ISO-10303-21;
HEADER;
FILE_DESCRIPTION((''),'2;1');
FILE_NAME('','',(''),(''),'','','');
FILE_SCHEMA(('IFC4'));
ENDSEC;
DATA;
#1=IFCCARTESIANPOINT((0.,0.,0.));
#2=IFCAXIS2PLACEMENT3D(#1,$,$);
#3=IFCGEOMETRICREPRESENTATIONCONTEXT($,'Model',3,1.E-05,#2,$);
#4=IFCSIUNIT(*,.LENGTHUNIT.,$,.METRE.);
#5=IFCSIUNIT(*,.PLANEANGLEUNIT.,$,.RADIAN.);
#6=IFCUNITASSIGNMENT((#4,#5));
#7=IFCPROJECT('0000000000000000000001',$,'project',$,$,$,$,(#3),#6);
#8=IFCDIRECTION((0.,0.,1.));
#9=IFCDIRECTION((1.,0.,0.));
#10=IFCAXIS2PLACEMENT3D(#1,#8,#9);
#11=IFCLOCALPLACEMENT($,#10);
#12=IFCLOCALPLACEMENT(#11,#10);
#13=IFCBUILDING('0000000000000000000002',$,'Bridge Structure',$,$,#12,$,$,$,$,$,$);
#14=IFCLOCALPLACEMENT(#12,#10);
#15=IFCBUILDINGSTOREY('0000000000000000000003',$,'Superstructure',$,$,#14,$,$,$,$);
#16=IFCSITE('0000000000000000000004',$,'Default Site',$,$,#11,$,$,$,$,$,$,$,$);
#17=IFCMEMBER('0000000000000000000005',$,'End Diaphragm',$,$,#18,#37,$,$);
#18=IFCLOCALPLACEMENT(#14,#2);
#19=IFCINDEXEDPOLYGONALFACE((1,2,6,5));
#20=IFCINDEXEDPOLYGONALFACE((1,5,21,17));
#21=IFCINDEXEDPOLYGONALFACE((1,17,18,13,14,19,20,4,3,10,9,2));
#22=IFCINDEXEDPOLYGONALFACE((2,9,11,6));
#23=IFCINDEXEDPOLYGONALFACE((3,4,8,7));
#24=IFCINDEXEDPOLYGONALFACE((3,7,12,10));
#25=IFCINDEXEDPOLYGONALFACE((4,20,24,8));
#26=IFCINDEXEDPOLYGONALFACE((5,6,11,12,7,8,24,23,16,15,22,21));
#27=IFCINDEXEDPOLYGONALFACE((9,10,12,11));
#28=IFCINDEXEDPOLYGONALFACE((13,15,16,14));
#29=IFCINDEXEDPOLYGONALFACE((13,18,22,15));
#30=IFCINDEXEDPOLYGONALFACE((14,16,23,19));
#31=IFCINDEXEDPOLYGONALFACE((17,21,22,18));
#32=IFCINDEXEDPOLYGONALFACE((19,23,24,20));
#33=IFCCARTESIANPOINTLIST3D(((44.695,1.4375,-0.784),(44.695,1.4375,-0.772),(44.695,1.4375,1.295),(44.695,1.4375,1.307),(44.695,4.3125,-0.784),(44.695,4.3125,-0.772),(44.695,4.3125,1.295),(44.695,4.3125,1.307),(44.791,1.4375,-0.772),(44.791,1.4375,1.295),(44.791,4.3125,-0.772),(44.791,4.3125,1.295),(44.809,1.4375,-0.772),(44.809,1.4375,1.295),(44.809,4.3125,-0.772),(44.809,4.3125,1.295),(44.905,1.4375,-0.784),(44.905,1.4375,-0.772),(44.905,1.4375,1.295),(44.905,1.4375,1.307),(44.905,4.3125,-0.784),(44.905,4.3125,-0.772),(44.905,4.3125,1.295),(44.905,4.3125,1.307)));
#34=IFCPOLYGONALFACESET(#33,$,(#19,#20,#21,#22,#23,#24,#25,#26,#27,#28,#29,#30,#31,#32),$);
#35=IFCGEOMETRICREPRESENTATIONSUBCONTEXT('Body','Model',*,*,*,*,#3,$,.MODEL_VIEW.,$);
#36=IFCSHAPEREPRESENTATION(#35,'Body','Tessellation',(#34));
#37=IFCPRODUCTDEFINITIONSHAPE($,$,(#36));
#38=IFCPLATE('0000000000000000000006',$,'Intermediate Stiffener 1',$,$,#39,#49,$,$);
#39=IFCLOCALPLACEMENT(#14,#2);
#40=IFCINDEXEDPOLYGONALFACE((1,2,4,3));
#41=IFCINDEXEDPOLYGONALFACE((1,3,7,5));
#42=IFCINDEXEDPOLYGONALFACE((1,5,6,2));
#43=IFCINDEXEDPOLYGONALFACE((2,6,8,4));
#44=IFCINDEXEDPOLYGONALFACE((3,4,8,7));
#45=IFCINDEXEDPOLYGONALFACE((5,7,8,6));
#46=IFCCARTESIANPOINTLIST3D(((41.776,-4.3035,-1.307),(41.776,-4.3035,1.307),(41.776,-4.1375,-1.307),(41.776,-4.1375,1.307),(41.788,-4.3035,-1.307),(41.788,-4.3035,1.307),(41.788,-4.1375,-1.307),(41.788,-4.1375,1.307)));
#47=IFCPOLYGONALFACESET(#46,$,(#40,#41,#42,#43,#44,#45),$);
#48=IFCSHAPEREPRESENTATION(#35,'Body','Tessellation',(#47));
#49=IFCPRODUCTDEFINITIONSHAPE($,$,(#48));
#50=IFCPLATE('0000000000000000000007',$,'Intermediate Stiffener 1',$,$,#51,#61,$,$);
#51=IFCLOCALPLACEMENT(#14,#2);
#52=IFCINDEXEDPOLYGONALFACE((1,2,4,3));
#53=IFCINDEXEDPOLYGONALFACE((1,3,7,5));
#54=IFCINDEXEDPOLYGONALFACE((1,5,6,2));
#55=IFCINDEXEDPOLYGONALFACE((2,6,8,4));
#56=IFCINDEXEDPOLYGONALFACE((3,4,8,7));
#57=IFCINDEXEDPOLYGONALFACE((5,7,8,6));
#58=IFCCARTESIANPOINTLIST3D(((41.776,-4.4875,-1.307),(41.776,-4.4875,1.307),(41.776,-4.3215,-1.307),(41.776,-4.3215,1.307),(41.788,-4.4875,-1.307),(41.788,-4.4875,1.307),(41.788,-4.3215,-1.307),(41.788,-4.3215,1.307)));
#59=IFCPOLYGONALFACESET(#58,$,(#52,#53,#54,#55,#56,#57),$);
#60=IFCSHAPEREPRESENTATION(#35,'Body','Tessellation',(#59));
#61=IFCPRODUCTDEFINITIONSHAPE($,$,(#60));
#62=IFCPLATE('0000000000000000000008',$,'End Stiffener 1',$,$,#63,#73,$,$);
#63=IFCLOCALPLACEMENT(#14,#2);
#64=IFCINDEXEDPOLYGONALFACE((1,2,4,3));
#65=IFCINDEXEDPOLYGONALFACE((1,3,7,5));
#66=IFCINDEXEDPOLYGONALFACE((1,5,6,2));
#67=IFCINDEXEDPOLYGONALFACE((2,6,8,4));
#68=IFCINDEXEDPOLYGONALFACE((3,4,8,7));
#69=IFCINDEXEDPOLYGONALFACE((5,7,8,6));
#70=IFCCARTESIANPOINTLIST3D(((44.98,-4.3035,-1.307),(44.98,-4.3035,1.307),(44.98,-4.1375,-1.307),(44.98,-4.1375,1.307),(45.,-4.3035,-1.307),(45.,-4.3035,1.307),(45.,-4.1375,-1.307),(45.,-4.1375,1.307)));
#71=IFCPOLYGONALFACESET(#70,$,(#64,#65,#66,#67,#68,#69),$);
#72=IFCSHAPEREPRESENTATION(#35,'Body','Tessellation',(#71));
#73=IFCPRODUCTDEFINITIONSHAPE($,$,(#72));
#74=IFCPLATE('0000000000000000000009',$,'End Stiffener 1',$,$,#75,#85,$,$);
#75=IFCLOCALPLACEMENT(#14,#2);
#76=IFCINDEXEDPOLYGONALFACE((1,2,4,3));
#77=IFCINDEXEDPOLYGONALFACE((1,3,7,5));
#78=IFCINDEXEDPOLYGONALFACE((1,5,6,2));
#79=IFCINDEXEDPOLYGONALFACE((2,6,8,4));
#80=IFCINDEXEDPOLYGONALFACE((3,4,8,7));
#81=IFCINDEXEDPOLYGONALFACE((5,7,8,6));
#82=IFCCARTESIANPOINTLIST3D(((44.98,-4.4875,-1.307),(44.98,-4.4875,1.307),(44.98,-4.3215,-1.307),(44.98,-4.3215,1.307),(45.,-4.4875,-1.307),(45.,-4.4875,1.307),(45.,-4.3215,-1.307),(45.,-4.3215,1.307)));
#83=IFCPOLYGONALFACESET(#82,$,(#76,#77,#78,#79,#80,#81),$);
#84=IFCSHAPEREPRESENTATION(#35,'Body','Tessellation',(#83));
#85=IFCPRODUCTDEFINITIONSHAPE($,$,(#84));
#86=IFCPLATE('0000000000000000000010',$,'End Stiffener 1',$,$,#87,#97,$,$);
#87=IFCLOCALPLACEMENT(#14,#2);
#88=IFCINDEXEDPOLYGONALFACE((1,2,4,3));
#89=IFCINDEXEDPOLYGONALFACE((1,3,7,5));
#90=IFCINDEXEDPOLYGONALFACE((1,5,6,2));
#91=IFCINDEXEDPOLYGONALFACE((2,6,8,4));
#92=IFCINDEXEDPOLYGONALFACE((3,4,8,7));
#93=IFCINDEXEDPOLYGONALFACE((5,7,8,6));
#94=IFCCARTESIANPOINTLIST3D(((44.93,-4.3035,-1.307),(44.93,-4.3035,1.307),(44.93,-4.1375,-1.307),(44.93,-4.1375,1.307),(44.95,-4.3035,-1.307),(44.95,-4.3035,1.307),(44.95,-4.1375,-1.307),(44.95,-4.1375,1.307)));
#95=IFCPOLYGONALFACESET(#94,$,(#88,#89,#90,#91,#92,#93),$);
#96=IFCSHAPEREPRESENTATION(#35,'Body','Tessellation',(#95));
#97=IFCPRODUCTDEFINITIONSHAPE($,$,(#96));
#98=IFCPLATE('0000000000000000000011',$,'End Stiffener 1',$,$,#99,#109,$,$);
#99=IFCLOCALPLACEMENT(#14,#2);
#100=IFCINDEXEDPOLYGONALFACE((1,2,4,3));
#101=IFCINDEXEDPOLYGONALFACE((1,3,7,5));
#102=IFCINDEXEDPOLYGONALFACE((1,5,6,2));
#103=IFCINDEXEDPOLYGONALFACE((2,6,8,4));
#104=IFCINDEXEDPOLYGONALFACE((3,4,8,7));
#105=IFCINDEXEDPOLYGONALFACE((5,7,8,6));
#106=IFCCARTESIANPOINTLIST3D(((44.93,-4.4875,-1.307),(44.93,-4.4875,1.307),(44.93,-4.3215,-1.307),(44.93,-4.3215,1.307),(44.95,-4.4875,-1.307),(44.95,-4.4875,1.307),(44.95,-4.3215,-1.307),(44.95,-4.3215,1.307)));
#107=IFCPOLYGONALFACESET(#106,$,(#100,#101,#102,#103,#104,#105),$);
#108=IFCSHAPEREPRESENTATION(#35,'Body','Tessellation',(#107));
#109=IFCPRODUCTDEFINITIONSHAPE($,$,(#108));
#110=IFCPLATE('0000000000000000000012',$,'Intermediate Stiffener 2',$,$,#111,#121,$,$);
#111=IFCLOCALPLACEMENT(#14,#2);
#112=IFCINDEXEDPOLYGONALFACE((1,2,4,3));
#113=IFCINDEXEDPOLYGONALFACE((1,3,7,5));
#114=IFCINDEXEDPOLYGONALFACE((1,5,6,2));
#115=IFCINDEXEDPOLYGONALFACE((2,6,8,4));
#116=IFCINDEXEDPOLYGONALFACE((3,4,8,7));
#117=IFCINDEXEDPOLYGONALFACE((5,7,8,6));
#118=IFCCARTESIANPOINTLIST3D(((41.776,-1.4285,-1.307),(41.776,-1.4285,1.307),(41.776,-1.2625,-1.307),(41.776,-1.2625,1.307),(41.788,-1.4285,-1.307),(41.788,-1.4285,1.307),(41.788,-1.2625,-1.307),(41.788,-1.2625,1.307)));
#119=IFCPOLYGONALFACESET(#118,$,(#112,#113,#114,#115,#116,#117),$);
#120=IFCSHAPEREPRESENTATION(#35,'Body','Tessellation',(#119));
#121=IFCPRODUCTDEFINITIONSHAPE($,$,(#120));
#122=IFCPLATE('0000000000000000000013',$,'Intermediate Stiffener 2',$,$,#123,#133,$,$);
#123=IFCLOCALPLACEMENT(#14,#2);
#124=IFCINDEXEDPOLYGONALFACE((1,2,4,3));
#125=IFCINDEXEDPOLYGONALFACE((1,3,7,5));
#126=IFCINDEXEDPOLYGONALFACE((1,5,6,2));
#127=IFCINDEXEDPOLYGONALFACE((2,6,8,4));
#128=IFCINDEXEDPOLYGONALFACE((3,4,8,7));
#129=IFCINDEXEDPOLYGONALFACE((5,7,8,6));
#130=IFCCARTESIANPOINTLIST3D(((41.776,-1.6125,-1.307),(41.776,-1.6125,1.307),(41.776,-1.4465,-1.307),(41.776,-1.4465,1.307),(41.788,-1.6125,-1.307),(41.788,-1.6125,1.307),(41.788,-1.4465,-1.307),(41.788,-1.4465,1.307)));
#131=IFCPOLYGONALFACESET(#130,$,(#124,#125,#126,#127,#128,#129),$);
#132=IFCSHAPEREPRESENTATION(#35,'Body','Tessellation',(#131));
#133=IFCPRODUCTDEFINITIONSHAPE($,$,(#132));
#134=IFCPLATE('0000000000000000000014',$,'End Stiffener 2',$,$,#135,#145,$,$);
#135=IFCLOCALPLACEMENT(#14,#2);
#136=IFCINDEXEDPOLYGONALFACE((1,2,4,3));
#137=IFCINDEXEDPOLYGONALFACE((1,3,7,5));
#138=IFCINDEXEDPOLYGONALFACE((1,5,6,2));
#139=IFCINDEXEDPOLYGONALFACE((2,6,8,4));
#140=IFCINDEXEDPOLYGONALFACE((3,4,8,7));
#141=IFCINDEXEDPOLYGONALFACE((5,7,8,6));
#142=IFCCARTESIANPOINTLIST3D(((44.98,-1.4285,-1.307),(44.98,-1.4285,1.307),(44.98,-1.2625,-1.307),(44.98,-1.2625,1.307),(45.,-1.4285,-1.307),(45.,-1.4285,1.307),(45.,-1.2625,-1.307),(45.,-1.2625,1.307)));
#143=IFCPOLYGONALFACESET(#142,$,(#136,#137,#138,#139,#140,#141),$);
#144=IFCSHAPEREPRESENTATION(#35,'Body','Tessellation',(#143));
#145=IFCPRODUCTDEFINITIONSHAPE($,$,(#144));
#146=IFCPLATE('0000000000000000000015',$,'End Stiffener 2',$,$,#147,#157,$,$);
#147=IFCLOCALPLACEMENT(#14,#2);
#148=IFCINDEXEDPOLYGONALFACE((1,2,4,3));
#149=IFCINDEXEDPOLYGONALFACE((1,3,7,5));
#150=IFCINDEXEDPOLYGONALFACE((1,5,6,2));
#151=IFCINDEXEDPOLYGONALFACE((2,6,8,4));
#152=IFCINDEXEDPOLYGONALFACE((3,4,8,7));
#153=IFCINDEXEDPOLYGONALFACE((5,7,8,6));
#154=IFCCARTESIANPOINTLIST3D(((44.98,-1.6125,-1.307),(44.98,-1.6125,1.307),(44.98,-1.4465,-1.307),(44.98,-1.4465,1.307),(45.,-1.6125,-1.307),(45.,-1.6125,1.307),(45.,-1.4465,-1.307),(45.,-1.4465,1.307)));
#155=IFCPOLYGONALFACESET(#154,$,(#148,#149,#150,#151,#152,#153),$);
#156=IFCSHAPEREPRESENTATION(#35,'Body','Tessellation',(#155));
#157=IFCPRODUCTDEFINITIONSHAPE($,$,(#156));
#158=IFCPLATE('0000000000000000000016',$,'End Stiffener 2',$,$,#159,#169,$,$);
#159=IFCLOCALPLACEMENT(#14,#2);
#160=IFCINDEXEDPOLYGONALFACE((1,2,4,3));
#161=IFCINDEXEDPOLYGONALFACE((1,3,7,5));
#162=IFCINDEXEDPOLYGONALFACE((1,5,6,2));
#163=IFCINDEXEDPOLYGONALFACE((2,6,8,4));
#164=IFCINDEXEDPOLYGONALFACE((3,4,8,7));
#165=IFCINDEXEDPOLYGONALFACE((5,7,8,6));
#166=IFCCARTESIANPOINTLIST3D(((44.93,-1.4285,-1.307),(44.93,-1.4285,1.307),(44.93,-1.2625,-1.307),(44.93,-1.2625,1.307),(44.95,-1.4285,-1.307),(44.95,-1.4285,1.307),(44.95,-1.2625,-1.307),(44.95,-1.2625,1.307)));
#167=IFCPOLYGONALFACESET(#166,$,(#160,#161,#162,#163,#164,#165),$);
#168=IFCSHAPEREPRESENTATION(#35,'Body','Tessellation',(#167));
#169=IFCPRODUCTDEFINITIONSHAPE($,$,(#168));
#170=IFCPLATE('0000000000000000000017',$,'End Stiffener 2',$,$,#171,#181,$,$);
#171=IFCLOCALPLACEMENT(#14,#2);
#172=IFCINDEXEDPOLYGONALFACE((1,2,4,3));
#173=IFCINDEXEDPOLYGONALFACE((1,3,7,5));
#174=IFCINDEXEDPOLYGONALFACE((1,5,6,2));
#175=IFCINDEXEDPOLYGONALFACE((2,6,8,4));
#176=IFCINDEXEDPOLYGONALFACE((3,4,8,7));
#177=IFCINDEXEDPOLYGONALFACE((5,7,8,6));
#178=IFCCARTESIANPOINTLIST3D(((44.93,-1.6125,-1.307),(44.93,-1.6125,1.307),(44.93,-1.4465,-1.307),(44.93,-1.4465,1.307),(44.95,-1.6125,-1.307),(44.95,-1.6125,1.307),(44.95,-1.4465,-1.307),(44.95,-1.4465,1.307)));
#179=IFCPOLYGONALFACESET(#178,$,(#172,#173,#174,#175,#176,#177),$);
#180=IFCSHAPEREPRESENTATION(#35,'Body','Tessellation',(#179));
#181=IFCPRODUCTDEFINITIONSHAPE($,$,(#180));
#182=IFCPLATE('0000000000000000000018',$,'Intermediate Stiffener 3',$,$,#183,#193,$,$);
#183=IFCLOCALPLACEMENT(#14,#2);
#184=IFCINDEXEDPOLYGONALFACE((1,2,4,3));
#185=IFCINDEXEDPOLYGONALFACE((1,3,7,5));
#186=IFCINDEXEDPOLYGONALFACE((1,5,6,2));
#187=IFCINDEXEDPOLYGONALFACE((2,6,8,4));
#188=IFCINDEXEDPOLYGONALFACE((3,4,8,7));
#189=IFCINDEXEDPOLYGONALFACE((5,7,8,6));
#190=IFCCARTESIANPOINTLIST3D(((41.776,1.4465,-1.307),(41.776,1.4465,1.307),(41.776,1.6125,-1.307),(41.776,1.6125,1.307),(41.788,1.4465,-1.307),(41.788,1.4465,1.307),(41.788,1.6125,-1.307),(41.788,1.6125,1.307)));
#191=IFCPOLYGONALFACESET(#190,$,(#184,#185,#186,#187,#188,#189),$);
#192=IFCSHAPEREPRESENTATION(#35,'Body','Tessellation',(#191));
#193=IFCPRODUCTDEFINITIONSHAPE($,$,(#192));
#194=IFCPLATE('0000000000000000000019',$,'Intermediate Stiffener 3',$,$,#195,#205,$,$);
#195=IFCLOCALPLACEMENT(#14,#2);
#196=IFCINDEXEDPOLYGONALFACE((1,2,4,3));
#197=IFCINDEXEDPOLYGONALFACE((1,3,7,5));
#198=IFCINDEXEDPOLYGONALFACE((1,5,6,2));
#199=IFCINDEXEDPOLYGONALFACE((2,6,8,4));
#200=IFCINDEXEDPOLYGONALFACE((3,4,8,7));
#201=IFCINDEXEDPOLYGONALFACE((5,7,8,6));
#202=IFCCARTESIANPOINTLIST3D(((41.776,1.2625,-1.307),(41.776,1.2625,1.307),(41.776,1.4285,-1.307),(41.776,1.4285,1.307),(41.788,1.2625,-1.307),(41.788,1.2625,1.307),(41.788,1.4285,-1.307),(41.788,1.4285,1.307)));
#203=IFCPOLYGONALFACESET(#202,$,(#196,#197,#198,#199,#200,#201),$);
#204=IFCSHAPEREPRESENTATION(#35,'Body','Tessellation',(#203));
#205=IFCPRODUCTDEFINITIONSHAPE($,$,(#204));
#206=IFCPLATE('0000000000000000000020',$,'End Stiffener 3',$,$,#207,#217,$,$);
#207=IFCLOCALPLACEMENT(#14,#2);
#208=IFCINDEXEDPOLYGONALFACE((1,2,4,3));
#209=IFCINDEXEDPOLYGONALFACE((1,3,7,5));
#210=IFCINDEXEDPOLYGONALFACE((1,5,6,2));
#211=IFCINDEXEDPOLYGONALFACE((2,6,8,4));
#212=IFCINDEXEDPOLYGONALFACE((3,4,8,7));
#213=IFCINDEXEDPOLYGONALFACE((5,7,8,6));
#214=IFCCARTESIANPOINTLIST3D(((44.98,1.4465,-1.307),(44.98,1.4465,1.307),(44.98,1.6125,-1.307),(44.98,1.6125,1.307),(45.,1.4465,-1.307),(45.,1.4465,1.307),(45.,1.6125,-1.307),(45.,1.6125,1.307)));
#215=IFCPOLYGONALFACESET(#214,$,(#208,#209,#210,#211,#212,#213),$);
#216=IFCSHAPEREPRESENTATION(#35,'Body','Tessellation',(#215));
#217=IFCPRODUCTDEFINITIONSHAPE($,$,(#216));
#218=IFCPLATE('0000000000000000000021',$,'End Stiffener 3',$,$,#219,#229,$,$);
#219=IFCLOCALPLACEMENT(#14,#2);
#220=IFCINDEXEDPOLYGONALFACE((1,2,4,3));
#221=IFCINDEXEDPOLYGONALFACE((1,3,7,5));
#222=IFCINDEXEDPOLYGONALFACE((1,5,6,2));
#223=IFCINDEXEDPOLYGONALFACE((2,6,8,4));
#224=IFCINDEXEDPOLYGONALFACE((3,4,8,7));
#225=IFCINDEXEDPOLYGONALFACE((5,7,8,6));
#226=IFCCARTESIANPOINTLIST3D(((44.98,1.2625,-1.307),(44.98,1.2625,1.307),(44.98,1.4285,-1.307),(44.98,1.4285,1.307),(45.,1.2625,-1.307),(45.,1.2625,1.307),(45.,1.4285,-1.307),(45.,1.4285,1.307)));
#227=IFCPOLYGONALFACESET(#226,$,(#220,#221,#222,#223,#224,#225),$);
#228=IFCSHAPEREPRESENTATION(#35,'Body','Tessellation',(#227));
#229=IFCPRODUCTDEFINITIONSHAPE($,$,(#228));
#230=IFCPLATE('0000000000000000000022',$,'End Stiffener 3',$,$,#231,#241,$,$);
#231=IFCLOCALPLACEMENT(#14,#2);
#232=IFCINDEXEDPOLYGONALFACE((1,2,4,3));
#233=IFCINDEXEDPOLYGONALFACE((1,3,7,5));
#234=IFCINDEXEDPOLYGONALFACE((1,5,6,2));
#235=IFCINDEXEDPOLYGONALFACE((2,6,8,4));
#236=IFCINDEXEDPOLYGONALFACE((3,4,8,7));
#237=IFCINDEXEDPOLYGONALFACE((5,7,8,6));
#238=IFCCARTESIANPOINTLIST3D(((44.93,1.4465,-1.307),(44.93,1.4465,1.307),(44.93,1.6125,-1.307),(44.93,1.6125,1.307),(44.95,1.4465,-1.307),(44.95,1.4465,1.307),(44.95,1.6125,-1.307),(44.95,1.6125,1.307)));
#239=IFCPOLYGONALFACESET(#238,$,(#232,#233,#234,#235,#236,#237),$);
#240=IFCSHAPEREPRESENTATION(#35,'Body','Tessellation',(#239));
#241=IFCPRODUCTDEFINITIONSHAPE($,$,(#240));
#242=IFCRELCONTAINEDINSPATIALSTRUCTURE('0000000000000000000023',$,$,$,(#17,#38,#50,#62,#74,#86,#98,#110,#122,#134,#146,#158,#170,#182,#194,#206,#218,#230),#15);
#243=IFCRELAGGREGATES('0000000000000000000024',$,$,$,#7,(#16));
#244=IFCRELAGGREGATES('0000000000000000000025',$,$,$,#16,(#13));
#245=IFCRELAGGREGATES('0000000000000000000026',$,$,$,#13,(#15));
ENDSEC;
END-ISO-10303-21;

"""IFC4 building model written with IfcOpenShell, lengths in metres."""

from ifc_helpers import new_model, si_unit, frame, origin, origin_with_axes, origin_2d_with_axis, place, context, subcontext, project, spatial, rectangle, i_section, extrude, element, save


model = new_model("IFC4")

# Units and contexts
model_context = context("Model", 3, precision=1e-05, world=origin())
body_context = subcontext(model_context, "Body", "Model", "MODEL_VIEW")
ifc_project = project(units=[si_unit("LENGTHUNIT", "METRE"), si_unit("PLANEANGLEUNIT", "RADIAN")], contexts=[model_context])

# Site, building, storey
site_placement = place(None, origin_with_axes())
site = spatial("IfcSite", under=ifc_project, at=site_placement, Name="Default Site")
building_placement = place(site_placement, origin_with_axes())
building = spatial("IfcBuilding", under=site, at=building_placement, Name="Bridge Structure")
storey_placement = place(building_placement, origin_with_axes())
storey = spatial("IfcBuildingStorey", under=building, at=storey_placement, Name="Superstructure")

# Member
for number, where, z_axis, x_axis, name in (
    (1, (44.8, 1.4375, 0.2615), (0.0, 1.0, 0.0), (-1.0, 0.0, 0.0), "End Diaphragm"),
):
    element("IfcMember", number, at=place(storey_placement, frame(where, z_axis=z_axis, x_axis=x_axis)), inside=storey, Name=name, context=body_context, shape_type="SweptSolid", body=[
        extrude(i_section(OverallWidth=0.21, OverallDepth=2.091, WebThickness=0.018, FlangeThickness=0.012, at=origin_2d_with_axis()), origin_with_axes(), (0.0, 0.0, 1.0), 2.875),
    ])

# Plates
for number, where, z_axis, x_axis, name in (
    (2, (41.782, -4.2205, -1.307), (0.0, 0.0, 1.0), (1.0, 0.0, 0.0), "Intermediate Stiffener 1"),
    (3, (41.782, -4.4045, -1.307), (0.0, 0.0, 1.0), (1.0, 0.0, 0.0), "Intermediate Stiffener 1"),
):
    element("IfcPlate", number, at=place(storey_placement, frame(where, z_axis=z_axis, x_axis=x_axis)), inside=storey, Name=name, context=body_context, shape_type="SweptSolid", body=[
        extrude(rectangle(XDim=0.012, YDim=0.166, at=origin_2d_with_axis()), origin_with_axes(), (0.0, 0.0, 1.0), 2.614),
    ])
for number, where, z_axis, x_axis, name in (
    (4, (44.99, -4.2205, -1.307), (0.0, 0.0, 1.0), (1.0, 0.0, 0.0), "End Stiffener 1"),
    (5, (44.99, -4.4045, -1.307), (0.0, 0.0, 1.0), (1.0, 0.0, 0.0), "End Stiffener 1"),
    (6, (44.94, -4.2205, -1.307), (0.0, 0.0, 1.0), (1.0, 0.0, 0.0), "End Stiffener 1"),
    (7, (44.94, -4.4045, -1.307), (0.0, 0.0, 1.0), (1.0, 0.0, 0.0), "End Stiffener 1"),
):
    element("IfcPlate", number, at=place(storey_placement, frame(where, z_axis=z_axis, x_axis=x_axis)), inside=storey, Name=name, context=body_context, shape_type="SweptSolid", body=[
        extrude(rectangle(XDim=0.02, YDim=0.166, at=origin_2d_with_axis()), origin_with_axes(), (0.0, 0.0, 1.0), 2.614),
    ])
for number, where, z_axis, x_axis, name in (
    (8, (41.782, -1.3455, -1.307), (0.0, 0.0, 1.0), (1.0, 0.0, 0.0), "Intermediate Stiffener 2"),
    (9, (41.782, -1.5295, -1.307), (0.0, 0.0, 1.0), (1.0, 0.0, 0.0), "Intermediate Stiffener 2"),
):
    element("IfcPlate", number, at=place(storey_placement, frame(where, z_axis=z_axis, x_axis=x_axis)), inside=storey, Name=name, context=body_context, shape_type="SweptSolid", body=[
        extrude(rectangle(XDim=0.012, YDim=0.166, at=origin_2d_with_axis()), origin_with_axes(), (0.0, 0.0, 1.0), 2.614),
    ])
for number, where, z_axis, x_axis, name in (
    (10, (44.99, -1.3455, -1.307), (0.0, 0.0, 1.0), (1.0, 0.0, 0.0), "End Stiffener 2"),
    (11, (44.99, -1.5295, -1.307), (0.0, 0.0, 1.0), (1.0, 0.0, 0.0), "End Stiffener 2"),
    (12, (44.94, -1.3455, -1.307), (0.0, 0.0, 1.0), (1.0, 0.0, 0.0), "End Stiffener 2"),
    (13, (44.94, -1.5295, -1.307), (0.0, 0.0, 1.0), (1.0, 0.0, 0.0), "End Stiffener 2"),
):
    element("IfcPlate", number, at=place(storey_placement, frame(where, z_axis=z_axis, x_axis=x_axis)), inside=storey, Name=name, context=body_context, shape_type="SweptSolid", body=[
        extrude(rectangle(XDim=0.02, YDim=0.166, at=origin_2d_with_axis()), origin_with_axes(), (0.0, 0.0, 1.0), 2.614),
    ])
for number, where, z_axis, x_axis, name in (
    (14, (41.782, 1.5295, -1.307), (0.0, 0.0, 1.0), (1.0, 0.0, 0.0), "Intermediate Stiffener 3"),
    (15, (41.782, 1.3455, -1.307), (0.0, 0.0, 1.0), (1.0, 0.0, 0.0), "Intermediate Stiffener 3"),
):
    element("IfcPlate", number, at=place(storey_placement, frame(where, z_axis=z_axis, x_axis=x_axis)), inside=storey, Name=name, context=body_context, shape_type="SweptSolid", body=[
        extrude(rectangle(XDim=0.012, YDim=0.166, at=origin_2d_with_axis()), origin_with_axes(), (0.0, 0.0, 1.0), 2.614),
    ])
for number, where, z_axis, x_axis, name in (
    (16, (44.99, 1.5295, -1.307), (0.0, 0.0, 1.0), (1.0, 0.0, 0.0), "End Stiffener 3"),
    (17, (44.99, 1.3455, -1.307), (0.0, 0.0, 1.0), (1.0, 0.0, 0.0), "End Stiffener 3"),
    (18, (44.94, 1.5295, -1.307), (0.0, 0.0, 1.0), (1.0, 0.0, 0.0), "End Stiffener 3"),
):
    element("IfcPlate", number, at=place(storey_placement, frame(where, z_axis=z_axis, x_axis=x_axis)), inside=storey, Name=name, context=body_context, shape_type="SweptSolid", body=[
        extrude(rectangle(XDim=0.02, YDim=0.166, at=origin_2d_with_axis()), origin_with_axes(), (0.0, 0.0, 1.0), 2.614),
    ])

save(model, "model.ifc")
